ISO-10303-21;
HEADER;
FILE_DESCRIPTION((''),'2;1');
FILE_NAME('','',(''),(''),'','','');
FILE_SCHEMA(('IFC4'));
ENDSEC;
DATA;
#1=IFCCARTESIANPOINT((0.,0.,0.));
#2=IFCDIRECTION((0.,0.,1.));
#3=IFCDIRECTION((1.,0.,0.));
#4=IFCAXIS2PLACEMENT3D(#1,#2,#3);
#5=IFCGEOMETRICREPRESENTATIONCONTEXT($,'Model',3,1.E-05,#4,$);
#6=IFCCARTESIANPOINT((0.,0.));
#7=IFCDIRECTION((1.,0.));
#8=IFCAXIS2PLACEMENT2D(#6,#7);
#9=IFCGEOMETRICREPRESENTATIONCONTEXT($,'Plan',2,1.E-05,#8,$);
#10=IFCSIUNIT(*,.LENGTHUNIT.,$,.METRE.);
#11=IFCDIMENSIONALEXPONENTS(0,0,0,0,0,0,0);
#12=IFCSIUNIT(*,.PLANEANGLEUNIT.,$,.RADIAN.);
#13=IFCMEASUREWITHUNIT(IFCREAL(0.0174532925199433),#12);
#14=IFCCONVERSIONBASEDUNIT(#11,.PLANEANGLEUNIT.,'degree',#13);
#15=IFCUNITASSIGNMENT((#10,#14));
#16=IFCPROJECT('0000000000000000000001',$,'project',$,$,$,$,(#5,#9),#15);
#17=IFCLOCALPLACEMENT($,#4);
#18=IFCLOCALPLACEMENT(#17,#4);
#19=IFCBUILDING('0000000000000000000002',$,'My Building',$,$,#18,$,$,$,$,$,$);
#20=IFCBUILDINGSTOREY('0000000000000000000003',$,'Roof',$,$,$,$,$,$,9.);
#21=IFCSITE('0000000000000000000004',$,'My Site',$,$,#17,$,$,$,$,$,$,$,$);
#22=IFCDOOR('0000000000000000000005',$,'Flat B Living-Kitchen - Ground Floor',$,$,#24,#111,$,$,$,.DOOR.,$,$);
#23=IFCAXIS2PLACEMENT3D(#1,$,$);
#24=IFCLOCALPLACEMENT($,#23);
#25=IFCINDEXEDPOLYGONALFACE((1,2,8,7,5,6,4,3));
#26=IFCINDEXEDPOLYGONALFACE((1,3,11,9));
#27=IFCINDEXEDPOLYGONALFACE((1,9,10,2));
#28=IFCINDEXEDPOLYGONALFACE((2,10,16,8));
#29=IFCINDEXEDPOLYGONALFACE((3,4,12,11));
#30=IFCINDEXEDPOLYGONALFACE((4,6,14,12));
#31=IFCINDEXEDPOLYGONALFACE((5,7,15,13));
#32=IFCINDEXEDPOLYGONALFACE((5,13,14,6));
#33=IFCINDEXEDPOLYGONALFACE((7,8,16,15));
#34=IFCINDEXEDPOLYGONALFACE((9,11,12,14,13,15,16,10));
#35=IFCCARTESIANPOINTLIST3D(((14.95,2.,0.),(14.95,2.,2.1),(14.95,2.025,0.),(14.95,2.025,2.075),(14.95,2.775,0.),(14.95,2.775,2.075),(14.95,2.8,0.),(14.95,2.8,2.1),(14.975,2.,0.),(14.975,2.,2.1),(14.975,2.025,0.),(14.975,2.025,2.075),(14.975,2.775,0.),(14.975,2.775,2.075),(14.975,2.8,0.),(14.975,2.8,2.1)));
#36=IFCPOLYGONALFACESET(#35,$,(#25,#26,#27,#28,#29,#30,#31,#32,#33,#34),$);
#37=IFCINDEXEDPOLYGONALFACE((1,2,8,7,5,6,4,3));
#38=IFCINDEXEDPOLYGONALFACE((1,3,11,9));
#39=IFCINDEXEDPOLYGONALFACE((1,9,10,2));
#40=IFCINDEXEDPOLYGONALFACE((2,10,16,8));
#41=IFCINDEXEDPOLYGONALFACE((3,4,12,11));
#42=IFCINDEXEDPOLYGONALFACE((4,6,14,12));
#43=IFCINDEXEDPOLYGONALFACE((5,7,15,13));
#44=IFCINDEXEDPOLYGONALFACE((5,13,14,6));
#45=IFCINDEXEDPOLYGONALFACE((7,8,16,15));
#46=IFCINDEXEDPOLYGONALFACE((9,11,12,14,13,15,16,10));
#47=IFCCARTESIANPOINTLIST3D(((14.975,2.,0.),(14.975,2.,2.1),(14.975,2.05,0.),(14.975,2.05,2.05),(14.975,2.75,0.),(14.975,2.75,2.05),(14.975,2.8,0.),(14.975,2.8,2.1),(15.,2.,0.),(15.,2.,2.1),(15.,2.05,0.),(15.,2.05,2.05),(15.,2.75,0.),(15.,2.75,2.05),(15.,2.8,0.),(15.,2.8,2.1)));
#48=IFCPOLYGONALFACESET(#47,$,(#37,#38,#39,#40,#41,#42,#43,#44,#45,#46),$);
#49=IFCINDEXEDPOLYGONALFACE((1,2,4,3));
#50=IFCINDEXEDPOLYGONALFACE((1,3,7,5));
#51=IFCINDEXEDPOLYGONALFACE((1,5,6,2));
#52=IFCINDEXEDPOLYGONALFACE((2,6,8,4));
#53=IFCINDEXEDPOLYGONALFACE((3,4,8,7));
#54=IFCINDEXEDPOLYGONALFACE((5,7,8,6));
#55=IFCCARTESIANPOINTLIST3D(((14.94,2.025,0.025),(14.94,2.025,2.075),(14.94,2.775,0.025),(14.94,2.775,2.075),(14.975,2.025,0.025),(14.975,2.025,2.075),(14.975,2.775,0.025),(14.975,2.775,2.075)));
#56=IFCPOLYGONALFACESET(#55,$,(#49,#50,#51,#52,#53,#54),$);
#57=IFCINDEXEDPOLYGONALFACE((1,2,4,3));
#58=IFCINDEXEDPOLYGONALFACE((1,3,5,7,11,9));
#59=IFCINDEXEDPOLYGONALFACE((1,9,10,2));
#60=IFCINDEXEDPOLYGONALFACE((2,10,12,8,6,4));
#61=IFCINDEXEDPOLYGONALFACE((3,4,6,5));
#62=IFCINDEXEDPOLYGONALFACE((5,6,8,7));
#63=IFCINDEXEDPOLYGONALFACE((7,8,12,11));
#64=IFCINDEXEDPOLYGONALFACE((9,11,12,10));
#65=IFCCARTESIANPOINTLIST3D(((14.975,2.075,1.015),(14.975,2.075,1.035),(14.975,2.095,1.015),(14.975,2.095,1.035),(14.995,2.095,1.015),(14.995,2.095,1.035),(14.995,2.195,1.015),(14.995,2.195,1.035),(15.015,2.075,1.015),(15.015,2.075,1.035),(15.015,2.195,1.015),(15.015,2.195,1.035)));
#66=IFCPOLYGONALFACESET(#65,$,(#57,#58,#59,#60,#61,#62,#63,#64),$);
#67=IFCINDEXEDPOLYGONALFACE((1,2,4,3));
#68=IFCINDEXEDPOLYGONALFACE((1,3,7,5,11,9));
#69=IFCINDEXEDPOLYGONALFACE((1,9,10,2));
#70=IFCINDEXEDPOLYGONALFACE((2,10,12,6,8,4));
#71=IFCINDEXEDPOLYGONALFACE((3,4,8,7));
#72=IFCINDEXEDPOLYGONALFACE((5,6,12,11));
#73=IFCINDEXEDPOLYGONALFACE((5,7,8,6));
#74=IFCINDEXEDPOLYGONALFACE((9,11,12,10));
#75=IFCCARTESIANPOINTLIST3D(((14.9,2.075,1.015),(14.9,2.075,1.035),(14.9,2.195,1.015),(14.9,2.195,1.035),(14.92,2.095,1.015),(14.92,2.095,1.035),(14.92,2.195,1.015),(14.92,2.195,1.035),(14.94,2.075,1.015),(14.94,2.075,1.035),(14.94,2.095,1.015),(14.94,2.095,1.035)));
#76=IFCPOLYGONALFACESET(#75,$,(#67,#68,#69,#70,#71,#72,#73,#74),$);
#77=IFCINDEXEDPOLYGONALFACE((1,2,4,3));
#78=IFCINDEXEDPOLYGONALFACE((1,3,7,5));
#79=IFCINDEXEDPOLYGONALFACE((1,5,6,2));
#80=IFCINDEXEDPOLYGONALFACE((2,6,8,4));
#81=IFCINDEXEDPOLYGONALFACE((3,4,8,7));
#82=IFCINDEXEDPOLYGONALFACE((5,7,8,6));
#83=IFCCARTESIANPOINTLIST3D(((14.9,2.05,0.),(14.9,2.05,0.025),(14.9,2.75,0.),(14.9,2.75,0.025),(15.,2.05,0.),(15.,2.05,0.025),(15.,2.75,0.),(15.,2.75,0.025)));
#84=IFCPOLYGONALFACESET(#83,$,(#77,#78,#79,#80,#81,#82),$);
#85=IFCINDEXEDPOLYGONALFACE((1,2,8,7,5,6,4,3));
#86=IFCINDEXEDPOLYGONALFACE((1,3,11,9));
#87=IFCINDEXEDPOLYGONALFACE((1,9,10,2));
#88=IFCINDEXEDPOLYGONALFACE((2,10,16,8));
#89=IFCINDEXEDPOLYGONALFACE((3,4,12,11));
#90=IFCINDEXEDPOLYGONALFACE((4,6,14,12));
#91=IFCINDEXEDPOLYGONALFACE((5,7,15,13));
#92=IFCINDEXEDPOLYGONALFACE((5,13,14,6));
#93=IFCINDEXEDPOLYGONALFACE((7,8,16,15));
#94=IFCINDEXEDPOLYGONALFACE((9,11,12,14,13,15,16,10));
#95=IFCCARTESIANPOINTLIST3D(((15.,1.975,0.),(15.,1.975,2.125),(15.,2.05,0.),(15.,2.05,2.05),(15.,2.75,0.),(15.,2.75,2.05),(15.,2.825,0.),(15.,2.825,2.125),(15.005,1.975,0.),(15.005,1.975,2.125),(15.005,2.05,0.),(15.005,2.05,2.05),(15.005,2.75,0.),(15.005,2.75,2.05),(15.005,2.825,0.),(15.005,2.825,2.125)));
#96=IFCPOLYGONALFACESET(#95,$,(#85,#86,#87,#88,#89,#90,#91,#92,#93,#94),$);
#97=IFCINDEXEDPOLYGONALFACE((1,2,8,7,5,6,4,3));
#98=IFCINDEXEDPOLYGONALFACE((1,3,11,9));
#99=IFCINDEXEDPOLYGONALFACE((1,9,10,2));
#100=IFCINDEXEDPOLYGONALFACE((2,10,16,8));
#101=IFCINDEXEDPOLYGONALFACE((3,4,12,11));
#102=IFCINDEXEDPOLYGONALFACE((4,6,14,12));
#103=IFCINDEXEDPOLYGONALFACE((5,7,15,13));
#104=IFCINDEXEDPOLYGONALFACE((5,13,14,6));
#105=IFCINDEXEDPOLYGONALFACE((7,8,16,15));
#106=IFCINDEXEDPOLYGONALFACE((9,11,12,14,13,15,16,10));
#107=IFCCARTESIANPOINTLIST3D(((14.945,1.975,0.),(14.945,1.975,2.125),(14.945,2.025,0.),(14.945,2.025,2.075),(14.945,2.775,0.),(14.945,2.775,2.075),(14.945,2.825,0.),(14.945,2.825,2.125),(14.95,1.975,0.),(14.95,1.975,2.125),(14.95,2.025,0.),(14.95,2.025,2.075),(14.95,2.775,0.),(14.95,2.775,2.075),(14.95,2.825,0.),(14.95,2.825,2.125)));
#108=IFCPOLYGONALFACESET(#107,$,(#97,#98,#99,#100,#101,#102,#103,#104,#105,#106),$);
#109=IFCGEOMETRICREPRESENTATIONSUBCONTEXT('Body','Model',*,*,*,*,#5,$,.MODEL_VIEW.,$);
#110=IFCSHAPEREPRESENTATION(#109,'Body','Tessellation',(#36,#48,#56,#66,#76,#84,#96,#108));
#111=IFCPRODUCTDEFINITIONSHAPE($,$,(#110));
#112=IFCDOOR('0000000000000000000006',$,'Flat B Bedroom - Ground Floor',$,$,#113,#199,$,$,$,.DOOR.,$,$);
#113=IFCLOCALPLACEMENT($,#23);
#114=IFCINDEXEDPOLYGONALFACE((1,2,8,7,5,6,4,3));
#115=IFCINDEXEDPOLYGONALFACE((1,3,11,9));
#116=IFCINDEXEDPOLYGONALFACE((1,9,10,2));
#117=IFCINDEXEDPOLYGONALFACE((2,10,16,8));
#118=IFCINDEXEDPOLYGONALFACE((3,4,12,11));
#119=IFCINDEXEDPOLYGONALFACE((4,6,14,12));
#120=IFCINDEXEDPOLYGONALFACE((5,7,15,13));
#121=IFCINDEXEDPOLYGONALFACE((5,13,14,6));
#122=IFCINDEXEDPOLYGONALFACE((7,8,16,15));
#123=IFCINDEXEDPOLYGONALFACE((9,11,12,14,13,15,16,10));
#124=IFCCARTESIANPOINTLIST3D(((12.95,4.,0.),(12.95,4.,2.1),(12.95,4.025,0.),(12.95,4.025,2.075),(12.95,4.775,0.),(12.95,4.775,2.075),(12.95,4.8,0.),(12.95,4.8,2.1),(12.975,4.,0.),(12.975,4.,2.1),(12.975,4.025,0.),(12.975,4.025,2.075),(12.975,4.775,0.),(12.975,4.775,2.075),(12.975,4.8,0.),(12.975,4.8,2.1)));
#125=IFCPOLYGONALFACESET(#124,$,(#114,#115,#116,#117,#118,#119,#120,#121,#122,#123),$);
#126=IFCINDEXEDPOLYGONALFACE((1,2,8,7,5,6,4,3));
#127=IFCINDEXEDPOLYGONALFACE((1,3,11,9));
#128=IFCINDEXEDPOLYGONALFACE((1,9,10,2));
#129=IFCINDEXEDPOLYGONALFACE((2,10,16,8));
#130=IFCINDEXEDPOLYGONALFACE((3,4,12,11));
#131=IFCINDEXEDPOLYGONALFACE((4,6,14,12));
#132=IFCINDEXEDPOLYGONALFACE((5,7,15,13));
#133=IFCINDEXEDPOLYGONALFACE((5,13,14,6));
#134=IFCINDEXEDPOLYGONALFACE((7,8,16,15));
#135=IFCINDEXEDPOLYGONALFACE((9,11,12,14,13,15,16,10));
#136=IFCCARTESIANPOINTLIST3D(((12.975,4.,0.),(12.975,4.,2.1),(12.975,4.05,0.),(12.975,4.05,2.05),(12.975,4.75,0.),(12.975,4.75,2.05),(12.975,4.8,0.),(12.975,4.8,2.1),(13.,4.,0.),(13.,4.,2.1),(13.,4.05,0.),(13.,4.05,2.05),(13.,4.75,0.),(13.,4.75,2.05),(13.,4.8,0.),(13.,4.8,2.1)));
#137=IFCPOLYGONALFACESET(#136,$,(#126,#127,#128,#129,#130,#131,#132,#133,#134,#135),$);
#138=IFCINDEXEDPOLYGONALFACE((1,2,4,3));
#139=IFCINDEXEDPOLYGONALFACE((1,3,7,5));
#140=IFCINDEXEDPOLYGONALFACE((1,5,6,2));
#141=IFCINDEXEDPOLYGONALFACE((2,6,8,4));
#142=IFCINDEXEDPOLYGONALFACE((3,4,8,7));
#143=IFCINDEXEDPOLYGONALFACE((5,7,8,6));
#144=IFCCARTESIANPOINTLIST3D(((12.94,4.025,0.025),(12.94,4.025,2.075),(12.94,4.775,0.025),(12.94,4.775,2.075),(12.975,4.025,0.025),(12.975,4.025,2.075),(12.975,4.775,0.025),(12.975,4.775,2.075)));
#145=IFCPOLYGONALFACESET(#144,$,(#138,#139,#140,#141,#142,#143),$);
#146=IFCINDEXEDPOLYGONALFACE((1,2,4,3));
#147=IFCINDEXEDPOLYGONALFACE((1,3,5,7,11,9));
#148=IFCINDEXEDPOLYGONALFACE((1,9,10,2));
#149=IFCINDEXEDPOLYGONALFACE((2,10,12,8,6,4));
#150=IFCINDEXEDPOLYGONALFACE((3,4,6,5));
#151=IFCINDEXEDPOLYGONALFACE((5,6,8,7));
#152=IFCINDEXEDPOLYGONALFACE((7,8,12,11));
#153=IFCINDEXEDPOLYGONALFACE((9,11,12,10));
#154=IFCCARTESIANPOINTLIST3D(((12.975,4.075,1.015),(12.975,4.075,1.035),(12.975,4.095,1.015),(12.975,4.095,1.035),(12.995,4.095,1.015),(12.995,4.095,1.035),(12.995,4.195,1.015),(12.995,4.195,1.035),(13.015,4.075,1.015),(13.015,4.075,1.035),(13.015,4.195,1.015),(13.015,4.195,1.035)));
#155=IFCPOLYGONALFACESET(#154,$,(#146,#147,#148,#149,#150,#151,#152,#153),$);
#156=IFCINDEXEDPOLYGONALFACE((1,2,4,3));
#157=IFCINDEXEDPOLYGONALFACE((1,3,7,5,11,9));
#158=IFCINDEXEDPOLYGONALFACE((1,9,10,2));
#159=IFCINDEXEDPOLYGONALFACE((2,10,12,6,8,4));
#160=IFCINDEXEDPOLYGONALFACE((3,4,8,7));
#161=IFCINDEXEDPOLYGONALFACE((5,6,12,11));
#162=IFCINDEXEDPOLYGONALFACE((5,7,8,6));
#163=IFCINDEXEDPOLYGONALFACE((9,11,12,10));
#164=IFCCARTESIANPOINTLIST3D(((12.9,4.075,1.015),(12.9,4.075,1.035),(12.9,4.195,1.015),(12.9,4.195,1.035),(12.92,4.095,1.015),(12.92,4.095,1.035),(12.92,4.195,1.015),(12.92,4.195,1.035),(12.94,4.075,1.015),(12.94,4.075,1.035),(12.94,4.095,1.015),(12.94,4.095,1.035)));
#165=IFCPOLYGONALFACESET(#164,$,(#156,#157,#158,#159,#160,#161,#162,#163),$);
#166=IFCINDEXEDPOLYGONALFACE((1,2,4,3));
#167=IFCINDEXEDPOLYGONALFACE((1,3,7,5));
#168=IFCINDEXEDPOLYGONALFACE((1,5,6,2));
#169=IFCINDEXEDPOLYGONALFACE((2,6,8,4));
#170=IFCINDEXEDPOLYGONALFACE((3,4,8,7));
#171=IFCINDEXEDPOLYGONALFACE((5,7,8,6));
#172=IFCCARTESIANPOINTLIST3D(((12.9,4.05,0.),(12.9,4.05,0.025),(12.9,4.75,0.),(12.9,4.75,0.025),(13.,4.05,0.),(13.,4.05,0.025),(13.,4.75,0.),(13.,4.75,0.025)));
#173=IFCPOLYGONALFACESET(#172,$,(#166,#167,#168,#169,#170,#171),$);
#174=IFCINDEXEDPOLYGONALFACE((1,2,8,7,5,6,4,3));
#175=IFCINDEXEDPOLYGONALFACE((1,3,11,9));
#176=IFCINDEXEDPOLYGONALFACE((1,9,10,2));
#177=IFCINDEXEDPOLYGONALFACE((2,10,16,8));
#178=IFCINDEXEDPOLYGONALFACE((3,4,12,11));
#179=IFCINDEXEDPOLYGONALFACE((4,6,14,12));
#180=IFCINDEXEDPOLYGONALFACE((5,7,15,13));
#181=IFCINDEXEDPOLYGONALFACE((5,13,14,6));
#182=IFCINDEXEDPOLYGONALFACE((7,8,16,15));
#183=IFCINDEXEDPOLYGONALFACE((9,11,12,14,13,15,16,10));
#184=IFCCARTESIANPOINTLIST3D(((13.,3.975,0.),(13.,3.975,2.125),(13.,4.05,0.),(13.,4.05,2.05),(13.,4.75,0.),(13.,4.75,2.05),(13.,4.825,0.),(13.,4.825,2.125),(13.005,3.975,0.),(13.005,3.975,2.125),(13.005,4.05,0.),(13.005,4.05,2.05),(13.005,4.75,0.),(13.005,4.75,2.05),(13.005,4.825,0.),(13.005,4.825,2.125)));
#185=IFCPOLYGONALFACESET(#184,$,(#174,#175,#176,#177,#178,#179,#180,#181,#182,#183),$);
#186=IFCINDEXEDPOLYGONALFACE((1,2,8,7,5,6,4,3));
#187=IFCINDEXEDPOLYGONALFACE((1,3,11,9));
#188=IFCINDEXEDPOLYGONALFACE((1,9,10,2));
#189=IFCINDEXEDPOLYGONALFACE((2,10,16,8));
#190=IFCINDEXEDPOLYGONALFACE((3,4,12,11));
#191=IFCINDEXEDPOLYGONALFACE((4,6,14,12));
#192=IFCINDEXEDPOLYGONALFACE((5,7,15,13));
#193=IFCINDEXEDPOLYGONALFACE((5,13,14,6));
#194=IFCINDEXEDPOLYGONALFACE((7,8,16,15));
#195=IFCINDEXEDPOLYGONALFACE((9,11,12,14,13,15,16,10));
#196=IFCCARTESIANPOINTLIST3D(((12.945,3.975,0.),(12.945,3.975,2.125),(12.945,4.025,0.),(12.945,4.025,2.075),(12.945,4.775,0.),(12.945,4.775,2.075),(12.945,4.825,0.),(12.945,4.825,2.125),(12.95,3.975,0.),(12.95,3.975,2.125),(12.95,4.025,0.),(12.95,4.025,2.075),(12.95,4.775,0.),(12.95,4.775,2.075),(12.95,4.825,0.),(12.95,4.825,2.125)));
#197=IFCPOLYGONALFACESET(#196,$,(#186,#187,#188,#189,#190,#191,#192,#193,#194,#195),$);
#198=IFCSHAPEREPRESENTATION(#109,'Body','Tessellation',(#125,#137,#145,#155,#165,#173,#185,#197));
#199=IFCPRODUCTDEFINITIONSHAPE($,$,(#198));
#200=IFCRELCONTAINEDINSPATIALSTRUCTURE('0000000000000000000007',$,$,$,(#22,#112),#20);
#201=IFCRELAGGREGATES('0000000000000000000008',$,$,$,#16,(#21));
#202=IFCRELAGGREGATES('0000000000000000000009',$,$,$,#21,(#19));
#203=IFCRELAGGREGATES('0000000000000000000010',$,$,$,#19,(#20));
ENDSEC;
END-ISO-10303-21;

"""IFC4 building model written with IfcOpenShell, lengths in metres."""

from ifc_helpers import new_model, entity, si_unit, converted_unit, frame, origin_with_axes, origin_2d_with_axis, place, context, subcontext, project, spatial, line, indexed_curve, outline, extrude, element, save


model = new_model("IFC4")

# Units and contexts
model_context = context("Model", 3, precision=1e-05, world=origin_with_axes())
plan_context = context("Plan", 2, precision=1e-05, world=origin_2d_with_axis())
body_context = subcontext(model_context, "Body", "Model", "MODEL_VIEW")
ifc_project = project(units=[si_unit("LENGTHUNIT", "METRE"), converted_unit("PLANEANGLEUNIT", "degree", entity("IfcReal", 0.0174532925199433), si_unit("PLANEANGLEUNIT", "RADIAN"), dimensions=[0, 0, 0, 0, 0, 0, 0])], contexts=[model_context, plan_context])

# Site, building, storey
site_placement = place(None, origin_with_axes())
site = spatial("IfcSite", under=ifc_project, at=site_placement, Name="My Site")
building_placement = place(site_placement, origin_with_axes())
building = spatial("IfcBuilding", under=site, at=building_placement, Name="My Building")
storey = spatial("IfcBuildingStorey", under=building, Name="Roof", Elevation=9.0)

# Doors
door_1_placement = place(None, frame((15.0, 2.0, 0.0), z_axis=(0.0, 0.0, 1.0), x_axis=(0.0, 1.0, 0.0)))
element("IfcDoor", 1, at=door_1_placement, inside=storey, Name="Flat B Living-Kitchen - Ground Floor", PredefinedType="DOOR", context=body_context, shape_type="SweptSolid", body=[
    extrude(outline(indexed_curve([(0.0, 0.0), (0.0, 2.1), (0.8, 2.1), (0.8, 0.0), (0.775, 0.0), (0.775, 2.075), (0.025, 2.075), (0.025, 0.0)], segments=[line(1, 2, 3, 4, 5, 6, 7, 8, 1)])), frame((0.0, 0.025, 0.0), z_axis=(0.0, -1.0, 0.0), x_axis=(1.0, 0.0, 0.0)), (0.0, 0.0, -1.0), 0.025),
    extrude(outline(indexed_curve([(0.0, 0.0), (0.0, 2.1), (0.8, 2.1), (0.8, 0.0), (0.75, 0.0), (0.75, 2.05), (0.05, 2.05), (0.05, 0.0)], segments=[line(1, 2, 3, 4, 5, 6, 7, 8, 1)])), frame((0.0, 0.0, 0.0), z_axis=(0.0, -1.0, 0.0), x_axis=(1.0, 0.0, 0.0)), (0.0, 0.0, -1.0), 0.025),
    extrude(outline(indexed_curve([(0.0, 0.0), (0.75, 0.0), (0.75, 0.035), (0.0, 0.035)], segments=[line(1, 2, 3, 4, 1)])), frame((0.025, 0.025, 0.025), z_axis=(0.0, 0.0, 1.0), x_axis=(1.0, 0.0, 0.0)), (0.0, 0.0, 1.0), 2.05),
    extrude(outline(indexed_curve([(0.0, 0.0), (0.0, -0.04), (0.12, -0.04), (0.12, -0.02), (0.02, -0.02), (0.02, 0.0)], segments=[line(1, 2, 3, 4, 5, 6, 1)])), frame((0.075, 0.025, 1.015), z_axis=(0.0, 0.0, 1.0), x_axis=(1.0, 0.0, 0.0)), (0.0, 0.0, 1.0), 0.02),
    extrude(outline(indexed_curve([(0.0, 0.0), (0.0, 0.04), (0.12, 0.04), (0.12, 0.02), (0.02, 0.02), (0.02, 0.0)], segments=[line(1, 2, 3, 4, 5, 6, 1)])), frame((0.075, 0.06, 1.015), z_axis=(0.0, 0.0, 1.0), x_axis=(1.0, 0.0, 0.0)), (0.0, 0.0, 1.0), 0.02),
    extrude(outline(indexed_curve([(0.0, 0.0), (0.7, 0.0), (0.7, 0.1), (0.0, 0.1)], segments=[line(1, 2, 3, 4, 1)])), frame((0.05, 0.0, 0.0), z_axis=(0.0, 0.0, 1.0), x_axis=(1.0, 0.0, 0.0)), (0.0, 0.0, 1.0), 0.025),
    extrude(outline(indexed_curve([(0.0, 0.0), (0.0, 2.125), (0.85, 2.125), (0.85, 0.0), (0.775, 0.0), (0.775, 2.05), (0.075, 2.05), (0.075, 0.0)], segments=[line(1, 2, 3, 4, 5, 6, 7, 8, 1)])), frame((-0.025, -0.005, 0.0), z_axis=(0.0, -1.0, 0.0), x_axis=(1.0, 0.0, 0.0)), (0.0, 0.0, -1.0), 0.005),
    extrude(outline(indexed_curve([(0.0, 0.0), (0.0, 2.125), (0.85, 2.125), (0.85, 0.0), (0.8, 0.0), (0.8, 2.075), (0.05, 2.075), (0.05, 0.0)], segments=[line(1, 2, 3, 4, 5, 6, 7, 8, 1)])), frame((-0.025, 0.05, 0.0), z_axis=(0.0, -1.0, 0.0), x_axis=(1.0, 0.0, 0.0)), (0.0, 0.0, -1.0), 0.005),
])
door_2_placement = place(None, frame((13.0, 4.0, 0.0), z_axis=(0.0, 0.0, 1.0), x_axis=(0.0, 1.0, 0.0)))
element("IfcDoor", 2, at=door_2_placement, inside=storey, Name="Flat B Bedroom - Ground Floor", PredefinedType="DOOR", context=body_context, shape_type="SweptSolid", body=[
    extrude(outline(indexed_curve([(0.0, 0.0), (0.0, 2.1), (0.8, 2.1), (0.8, 0.0), (0.775, 0.0), (0.775, 2.075), (0.025, 2.075), (0.025, 0.0)], segments=[line(1, 2, 3, 4, 5, 6, 7, 8, 1)])), frame((0.0, 0.025, 0.0), z_axis=(0.0, -1.0, 0.0), x_axis=(1.0, 0.0, 0.0)), (0.0, 0.0, -1.0), 0.025),
    extrude(outline(indexed_curve([(0.0, 0.0), (0.0, 2.1), (0.8, 2.1), (0.8, 0.0), (0.75, 0.0), (0.75, 2.05), (0.05, 2.05), (0.05, 0.0)], segments=[line(1, 2, 3, 4, 5, 6, 7, 8, 1)])), frame((0.0, 0.0, 0.0), z_axis=(0.0, -1.0, 0.0), x_axis=(1.0, 0.0, 0.0)), (0.0, 0.0, -1.0), 0.025),
    extrude(outline(indexed_curve([(0.0, 0.0), (0.75, 0.0), (0.75, 0.035), (0.0, 0.035)], segments=[line(1, 2, 3, 4, 1)])), frame((0.025, 0.025, 0.025), z_axis=(0.0, 0.0, 1.0), x_axis=(1.0, 0.0, 0.0)), (0.0, 0.0, 1.0), 2.05),
    extrude(outline(indexed_curve([(0.0, 0.0), (0.0, -0.04), (0.12, -0.04), (0.12, -0.02), (0.02, -0.02), (0.02, 0.0)], segments=[line(1, 2, 3, 4, 5, 6, 1)])), frame((0.075, 0.025, 1.015), z_axis=(0.0, 0.0, 1.0), x_axis=(1.0, 0.0, 0.0)), (0.0, 0.0, 1.0), 0.02),
    extrude(outline(indexed_curve([(0.0, 0.0), (0.0, 0.04), (0.12, 0.04), (0.12, 0.02), (0.02, 0.02), (0.02, 0.0)], segments=[line(1, 2, 3, 4, 5, 6, 1)])), frame((0.075, 0.06, 1.015), z_axis=(0.0, 0.0, 1.0), x_axis=(1.0, 0.0, 0.0)), (0.0, 0.0, 1.0), 0.02),
    extrude(outline(indexed_curve([(0.0, 0.0), (0.7, 0.0), (0.7, 0.1), (0.0, 0.1)], segments=[line(1, 2, 3, 4, 1)])), frame((0.05, 0.0, 0.0), z_axis=(0.0, 0.0, 1.0), x_axis=(1.0, 0.0, 0.0)), (0.0, 0.0, 1.0), 0.025),
    extrude(outline(indexed_curve([(0.0, 0.0), (0.0, 2.125), (0.85, 2.125), (0.85, 0.0), (0.775, 0.0), (0.775, 2.05), (0.075, 2.05), (0.075, 0.0)], segments=[line(1, 2, 3, 4, 5, 6, 7, 8, 1)])), frame((-0.025, -0.005, 0.0), z_axis=(0.0, -1.0, 0.0), x_axis=(1.0, 0.0, 0.0)), (0.0, 0.0, -1.0), 0.005),
    extrude(outline(indexed_curve([(0.0, 0.0), (0.0, 2.125), (0.85, 2.125), (0.85, 0.0), (0.8, 0.0), (0.8, 2.075), (0.05, 2.075), (0.05, 0.0)], segments=[line(1, 2, 3, 4, 5, 6, 7, 8, 1)])), frame((-0.025, 0.05, 0.0), z_axis=(0.0, -1.0, 0.0), x_axis=(1.0, 0.0, 0.0)), (0.0, 0.0, -1.0), 0.005),
])

save(model, "model.ifc")
